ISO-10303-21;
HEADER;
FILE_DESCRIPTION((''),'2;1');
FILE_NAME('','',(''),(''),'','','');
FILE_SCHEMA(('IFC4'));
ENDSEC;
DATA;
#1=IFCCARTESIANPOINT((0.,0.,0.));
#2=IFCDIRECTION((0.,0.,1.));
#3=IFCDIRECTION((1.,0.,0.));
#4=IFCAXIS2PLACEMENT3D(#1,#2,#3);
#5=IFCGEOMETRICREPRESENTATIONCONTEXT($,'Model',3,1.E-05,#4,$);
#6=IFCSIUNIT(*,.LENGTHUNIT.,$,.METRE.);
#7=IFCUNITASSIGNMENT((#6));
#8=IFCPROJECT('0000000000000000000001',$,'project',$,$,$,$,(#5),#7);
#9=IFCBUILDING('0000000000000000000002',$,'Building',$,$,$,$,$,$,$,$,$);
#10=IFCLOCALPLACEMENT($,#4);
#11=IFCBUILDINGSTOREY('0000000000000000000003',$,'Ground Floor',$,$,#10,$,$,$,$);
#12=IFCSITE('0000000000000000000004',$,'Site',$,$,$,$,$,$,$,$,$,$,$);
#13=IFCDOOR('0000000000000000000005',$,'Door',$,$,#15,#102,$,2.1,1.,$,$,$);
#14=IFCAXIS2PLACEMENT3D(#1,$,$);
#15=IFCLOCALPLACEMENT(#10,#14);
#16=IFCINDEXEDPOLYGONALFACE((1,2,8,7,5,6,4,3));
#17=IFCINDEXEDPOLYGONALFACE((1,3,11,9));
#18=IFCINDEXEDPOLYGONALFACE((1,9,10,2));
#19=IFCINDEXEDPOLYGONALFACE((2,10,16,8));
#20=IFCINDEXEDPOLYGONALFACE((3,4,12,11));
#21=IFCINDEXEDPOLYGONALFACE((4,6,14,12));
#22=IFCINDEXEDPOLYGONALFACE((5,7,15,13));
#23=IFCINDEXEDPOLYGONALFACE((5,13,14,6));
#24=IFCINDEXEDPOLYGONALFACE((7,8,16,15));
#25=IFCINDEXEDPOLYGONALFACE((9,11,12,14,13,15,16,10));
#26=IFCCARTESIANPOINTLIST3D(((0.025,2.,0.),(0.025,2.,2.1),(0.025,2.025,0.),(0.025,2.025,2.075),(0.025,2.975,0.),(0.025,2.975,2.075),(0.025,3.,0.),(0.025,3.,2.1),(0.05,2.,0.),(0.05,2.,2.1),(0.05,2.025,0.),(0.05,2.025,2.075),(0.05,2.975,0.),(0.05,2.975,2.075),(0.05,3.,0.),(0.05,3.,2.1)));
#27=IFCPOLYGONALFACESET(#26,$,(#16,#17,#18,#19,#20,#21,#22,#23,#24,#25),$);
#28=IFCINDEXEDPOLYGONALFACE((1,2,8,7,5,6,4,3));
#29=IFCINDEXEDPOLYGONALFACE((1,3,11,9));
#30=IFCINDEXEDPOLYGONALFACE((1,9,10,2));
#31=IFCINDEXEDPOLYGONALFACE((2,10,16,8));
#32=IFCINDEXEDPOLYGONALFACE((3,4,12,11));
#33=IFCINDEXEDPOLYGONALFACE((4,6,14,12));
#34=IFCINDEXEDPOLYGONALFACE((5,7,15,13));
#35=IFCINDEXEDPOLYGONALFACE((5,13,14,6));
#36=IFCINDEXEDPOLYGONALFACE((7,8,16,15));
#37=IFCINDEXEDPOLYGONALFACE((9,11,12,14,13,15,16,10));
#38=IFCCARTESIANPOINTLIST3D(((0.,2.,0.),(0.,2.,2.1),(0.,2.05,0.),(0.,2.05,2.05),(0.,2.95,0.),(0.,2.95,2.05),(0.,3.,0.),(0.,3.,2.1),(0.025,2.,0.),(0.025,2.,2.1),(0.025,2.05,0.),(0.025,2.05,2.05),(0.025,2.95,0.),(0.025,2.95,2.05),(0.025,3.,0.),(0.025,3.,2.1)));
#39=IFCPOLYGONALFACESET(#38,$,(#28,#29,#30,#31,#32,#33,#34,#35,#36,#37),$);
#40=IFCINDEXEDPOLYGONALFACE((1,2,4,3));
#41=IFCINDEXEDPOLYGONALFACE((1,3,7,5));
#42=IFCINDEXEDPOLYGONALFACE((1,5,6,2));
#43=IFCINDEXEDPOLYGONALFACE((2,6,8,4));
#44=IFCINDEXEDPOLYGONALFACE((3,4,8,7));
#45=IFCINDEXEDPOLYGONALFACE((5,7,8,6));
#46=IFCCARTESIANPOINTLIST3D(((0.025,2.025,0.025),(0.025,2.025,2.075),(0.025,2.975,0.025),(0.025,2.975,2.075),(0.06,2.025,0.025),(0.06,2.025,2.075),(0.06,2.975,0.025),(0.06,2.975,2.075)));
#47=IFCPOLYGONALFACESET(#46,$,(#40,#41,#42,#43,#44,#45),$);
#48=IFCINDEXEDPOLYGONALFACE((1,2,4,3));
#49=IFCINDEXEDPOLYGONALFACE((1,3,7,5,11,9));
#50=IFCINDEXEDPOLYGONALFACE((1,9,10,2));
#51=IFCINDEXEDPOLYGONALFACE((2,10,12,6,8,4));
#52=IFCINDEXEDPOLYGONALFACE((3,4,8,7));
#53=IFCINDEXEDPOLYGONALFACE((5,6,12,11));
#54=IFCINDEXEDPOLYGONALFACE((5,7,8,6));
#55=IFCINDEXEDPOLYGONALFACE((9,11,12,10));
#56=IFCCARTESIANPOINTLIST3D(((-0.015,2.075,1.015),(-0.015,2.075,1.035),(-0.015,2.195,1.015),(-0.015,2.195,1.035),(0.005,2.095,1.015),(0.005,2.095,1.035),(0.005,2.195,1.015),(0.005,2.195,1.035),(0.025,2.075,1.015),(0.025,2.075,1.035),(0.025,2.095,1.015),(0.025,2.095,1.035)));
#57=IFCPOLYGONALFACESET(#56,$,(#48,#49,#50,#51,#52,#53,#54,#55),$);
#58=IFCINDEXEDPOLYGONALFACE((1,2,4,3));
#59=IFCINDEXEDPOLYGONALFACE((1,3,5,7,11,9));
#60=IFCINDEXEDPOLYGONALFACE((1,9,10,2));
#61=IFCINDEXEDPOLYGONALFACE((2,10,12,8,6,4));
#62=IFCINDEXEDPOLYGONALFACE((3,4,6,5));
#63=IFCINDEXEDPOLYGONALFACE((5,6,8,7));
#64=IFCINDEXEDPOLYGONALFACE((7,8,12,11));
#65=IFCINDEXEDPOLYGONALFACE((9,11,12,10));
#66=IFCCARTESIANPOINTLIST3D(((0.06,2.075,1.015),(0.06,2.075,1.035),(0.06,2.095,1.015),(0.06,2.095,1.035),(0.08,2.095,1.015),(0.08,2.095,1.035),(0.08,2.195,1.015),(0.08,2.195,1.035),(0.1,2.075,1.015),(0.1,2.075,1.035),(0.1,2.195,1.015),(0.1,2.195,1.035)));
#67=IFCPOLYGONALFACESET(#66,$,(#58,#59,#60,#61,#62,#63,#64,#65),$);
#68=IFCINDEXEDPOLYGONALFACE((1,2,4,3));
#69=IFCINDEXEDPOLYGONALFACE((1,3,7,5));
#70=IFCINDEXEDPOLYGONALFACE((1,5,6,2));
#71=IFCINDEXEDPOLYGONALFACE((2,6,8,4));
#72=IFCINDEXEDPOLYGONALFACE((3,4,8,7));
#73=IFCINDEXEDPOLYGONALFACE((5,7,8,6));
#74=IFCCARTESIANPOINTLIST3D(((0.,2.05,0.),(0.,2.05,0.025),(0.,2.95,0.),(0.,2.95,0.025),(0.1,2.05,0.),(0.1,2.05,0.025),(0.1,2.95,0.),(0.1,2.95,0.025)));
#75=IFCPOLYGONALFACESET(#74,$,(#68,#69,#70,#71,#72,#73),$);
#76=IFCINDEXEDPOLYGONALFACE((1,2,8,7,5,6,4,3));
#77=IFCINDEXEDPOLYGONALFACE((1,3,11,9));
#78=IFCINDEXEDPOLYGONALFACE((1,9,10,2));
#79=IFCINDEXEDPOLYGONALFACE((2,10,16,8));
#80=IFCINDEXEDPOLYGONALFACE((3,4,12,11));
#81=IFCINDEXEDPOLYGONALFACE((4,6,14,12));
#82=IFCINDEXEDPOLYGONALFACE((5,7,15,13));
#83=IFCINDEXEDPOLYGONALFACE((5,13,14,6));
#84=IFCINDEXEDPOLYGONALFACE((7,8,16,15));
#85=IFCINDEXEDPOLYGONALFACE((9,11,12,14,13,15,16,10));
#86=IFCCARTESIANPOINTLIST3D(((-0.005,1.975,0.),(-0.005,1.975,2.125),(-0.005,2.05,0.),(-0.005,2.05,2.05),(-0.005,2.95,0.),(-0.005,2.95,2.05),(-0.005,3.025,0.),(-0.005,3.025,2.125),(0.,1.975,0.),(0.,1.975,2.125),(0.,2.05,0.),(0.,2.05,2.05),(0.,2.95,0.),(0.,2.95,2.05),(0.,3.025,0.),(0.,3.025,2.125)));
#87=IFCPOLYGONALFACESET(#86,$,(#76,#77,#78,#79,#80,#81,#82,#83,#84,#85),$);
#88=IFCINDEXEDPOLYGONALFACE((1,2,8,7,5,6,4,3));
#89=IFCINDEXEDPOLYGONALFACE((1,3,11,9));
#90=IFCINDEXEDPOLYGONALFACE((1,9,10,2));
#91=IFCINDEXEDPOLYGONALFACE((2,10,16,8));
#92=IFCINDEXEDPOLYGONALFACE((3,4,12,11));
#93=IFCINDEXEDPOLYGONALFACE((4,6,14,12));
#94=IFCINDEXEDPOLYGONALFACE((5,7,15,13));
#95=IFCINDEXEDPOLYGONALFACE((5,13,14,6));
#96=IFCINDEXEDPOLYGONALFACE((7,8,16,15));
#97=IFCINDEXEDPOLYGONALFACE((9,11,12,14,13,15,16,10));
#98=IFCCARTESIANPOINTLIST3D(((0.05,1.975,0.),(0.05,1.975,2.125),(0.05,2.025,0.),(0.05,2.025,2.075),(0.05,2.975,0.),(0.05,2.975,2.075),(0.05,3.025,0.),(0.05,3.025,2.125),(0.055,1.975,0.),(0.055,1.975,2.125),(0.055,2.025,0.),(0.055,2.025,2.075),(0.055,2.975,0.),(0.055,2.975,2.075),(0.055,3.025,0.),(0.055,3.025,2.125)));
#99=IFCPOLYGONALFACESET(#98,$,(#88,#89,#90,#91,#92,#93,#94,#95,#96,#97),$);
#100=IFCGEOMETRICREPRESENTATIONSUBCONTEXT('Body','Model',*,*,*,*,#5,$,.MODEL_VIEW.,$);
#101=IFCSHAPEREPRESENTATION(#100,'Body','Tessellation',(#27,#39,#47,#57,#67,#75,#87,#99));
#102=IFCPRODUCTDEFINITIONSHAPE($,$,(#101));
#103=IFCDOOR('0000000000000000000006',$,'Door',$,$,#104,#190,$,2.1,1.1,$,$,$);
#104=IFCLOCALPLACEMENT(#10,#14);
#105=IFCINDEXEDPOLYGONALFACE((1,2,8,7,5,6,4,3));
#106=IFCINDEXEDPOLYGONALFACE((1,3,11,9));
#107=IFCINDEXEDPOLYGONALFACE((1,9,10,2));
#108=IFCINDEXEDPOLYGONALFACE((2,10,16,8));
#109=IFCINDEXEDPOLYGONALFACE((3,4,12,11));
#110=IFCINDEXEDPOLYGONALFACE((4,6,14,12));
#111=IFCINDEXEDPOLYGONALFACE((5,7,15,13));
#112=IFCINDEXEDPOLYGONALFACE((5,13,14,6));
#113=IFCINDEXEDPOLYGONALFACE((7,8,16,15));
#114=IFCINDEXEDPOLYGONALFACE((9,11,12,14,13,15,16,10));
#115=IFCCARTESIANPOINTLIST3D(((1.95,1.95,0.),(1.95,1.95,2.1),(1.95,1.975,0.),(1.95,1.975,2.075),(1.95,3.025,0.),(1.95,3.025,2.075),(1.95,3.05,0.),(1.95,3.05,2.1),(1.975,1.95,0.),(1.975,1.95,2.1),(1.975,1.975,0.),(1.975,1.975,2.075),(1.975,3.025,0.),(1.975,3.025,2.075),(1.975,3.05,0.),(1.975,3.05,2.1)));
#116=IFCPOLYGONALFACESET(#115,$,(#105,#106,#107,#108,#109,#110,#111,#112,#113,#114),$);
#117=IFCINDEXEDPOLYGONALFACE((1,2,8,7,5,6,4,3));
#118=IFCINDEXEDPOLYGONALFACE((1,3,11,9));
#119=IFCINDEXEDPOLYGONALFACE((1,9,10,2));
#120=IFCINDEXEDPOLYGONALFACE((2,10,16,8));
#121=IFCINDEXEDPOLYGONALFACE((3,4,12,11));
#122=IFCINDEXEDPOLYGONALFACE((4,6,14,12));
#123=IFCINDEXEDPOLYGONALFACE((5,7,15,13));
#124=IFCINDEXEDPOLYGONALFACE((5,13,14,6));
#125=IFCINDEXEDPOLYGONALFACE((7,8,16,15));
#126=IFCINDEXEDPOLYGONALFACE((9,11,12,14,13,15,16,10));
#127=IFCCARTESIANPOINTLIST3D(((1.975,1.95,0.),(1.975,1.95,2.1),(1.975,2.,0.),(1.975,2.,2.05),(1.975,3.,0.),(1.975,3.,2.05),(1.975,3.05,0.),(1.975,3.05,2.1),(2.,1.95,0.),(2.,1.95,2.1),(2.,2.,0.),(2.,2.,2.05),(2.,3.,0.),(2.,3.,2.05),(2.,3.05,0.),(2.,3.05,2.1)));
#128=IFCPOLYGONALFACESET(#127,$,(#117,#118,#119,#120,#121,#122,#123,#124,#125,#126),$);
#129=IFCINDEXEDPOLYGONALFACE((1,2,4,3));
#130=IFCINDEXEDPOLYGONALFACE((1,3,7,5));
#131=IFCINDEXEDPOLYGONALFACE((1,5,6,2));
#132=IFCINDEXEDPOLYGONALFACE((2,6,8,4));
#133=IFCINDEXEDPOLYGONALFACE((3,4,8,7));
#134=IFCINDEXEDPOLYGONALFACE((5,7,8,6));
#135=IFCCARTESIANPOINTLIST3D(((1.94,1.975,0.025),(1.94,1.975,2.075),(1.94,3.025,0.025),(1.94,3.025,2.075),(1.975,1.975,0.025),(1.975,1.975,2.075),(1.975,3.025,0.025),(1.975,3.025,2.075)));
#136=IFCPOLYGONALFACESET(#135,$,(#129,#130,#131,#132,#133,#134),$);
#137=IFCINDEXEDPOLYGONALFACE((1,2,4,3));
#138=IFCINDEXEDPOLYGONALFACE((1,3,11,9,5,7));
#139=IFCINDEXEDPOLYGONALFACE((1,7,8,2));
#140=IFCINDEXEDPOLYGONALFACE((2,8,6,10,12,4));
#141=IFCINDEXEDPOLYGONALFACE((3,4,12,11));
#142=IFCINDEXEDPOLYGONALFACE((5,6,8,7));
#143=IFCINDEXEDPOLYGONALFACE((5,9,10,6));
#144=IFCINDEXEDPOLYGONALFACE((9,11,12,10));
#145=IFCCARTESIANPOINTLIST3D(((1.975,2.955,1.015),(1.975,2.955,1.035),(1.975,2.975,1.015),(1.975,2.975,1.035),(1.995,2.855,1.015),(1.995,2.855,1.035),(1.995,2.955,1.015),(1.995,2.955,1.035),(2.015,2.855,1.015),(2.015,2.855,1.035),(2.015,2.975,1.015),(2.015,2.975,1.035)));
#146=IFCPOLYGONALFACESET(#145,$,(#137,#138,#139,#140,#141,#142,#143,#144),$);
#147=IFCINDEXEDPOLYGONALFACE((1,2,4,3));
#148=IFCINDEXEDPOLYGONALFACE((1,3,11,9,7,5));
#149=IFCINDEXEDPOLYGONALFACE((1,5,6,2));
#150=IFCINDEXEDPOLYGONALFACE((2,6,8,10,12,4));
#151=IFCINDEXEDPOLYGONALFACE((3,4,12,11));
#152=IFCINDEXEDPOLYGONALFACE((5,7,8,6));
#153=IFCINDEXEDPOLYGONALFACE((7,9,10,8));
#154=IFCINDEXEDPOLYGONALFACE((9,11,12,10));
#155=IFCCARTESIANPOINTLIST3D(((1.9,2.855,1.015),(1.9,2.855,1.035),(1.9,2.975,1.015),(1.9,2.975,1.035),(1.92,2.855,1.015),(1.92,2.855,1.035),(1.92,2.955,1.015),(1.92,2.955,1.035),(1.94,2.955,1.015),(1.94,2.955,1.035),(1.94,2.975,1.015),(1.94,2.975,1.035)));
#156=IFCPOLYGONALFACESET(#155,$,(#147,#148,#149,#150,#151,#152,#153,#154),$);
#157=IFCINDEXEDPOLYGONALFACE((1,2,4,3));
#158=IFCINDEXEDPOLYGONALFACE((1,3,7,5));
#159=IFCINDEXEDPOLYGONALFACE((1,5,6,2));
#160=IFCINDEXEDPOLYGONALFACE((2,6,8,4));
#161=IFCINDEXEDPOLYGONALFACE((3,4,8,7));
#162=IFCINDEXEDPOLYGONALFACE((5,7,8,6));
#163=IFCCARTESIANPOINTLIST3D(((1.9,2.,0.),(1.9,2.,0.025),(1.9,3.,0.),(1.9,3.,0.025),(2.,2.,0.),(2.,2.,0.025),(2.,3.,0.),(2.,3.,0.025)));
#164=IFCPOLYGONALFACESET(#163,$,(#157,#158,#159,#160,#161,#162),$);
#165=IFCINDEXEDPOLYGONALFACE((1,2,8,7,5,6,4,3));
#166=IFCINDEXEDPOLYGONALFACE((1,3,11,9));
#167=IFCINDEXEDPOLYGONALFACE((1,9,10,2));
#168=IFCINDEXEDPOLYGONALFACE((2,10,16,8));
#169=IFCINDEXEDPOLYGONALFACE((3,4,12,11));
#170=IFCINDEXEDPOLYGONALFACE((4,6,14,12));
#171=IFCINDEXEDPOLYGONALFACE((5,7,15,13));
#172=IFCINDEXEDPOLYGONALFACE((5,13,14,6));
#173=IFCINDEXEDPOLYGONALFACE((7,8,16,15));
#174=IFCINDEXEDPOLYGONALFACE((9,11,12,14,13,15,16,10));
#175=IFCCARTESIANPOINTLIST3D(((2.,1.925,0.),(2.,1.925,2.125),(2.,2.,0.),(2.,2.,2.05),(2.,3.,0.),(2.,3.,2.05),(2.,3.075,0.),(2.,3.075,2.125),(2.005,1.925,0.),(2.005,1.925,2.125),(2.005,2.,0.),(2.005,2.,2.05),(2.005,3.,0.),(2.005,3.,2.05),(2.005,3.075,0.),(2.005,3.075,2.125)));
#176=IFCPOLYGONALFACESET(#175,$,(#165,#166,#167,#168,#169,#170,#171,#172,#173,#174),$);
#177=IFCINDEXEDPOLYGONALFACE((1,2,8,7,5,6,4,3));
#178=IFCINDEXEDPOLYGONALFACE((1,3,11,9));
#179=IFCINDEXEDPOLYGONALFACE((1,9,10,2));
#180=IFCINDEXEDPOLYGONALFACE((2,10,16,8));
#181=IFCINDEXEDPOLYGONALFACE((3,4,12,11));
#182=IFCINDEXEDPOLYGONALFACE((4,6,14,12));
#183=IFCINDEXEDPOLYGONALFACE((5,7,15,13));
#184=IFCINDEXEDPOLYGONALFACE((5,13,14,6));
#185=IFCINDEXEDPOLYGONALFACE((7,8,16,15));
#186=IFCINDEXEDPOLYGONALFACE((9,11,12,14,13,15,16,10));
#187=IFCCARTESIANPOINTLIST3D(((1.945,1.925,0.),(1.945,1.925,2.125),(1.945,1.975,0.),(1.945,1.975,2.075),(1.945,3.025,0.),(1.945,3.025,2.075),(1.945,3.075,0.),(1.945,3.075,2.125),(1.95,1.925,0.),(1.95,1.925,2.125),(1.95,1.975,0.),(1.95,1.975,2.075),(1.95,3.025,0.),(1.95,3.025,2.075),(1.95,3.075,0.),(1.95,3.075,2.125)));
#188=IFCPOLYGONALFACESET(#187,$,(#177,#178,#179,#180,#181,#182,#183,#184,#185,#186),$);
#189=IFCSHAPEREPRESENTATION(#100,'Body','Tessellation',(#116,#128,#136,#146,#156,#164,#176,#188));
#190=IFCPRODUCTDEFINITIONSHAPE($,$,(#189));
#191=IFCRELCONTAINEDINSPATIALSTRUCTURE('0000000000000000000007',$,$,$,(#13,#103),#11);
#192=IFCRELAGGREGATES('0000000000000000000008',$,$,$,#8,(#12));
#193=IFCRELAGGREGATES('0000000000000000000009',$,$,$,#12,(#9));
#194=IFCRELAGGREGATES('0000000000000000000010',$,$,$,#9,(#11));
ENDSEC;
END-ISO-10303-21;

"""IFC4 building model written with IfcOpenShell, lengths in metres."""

from ifc_helpers import new_model, si_unit, frame, origin_with_axes, place, context, subcontext, project, spatial, line, indexed_curve, outline, extrude, element, save


model = new_model("IFC4")

# Units and contexts
model_context = context("Model", 3, precision=1e-05, world=origin_with_axes())
body_context = subcontext(model_context, "Body", "Model", "MODEL_VIEW")
ifc_project = project(units=[si_unit("LENGTHUNIT", "METRE")], contexts=[model_context])

# Site, building, storey
site = spatial("IfcSite", under=ifc_project, Name="Site")
building = spatial("IfcBuilding", under=site, Name="Building")
storey_placement = place(None, origin_with_axes())
storey = spatial("IfcBuildingStorey", under=building, at=storey_placement, Name="Ground Floor")

# Doors
door_1_placement = place(storey_placement, frame((0.0, 3.0, 0.0), z_axis=(0.0, 0.0, 1.0), x_axis=(0.0, -1.0, 0.0)))
element("IfcDoor", 1, at=door_1_placement, inside=storey, Name="Door", OverallHeight=2.1, OverallWidth=1.0, context=body_context, shape_type="SweptSolid", body=[
    extrude(outline(indexed_curve([(0.0, 0.0), (0.0, 2.1), (1.0, 2.1), (1.0, 0.0), (0.975, 0.0), (0.975, 2.075), (0.025, 2.075), (0.025, 0.0)], segments=[line(1, 2, 3, 4, 5, 6, 7, 8, 1)])), frame((0.0, 0.025, 0.0), z_axis=(0.0, -1.0, 0.0), x_axis=(1.0, 0.0, 0.0)), (0.0, 0.0, -1.0), 0.025),
    extrude(outline(indexed_curve([(0.0, 0.0), (0.0, 2.1), (1.0, 2.1), (1.0, 0.0), (0.95, 0.0), (0.95, 2.05), (0.05, 2.05), (0.05, 0.0)], segments=[line(1, 2, 3, 4, 5, 6, 7, 8, 1)])), frame((0.0, 0.0, 0.0), z_axis=(0.0, -1.0, 0.0), x_axis=(1.0, 0.0, 0.0)), (0.0, 0.0, -1.0), 0.025),
    extrude(outline(indexed_curve([(0.0, 0.0), (0.95, 0.0), (0.95, 0.035), (0.0, 0.035)], segments=[line(1, 2, 3, 4, 1)])), frame((0.025, 0.025, 0.025), z_axis=(0.0, 0.0, 1.0), x_axis=(1.0, 0.0, 0.0)), (0.0, 0.0, 1.0), 2.05),
    extrude(outline(indexed_curve([(0.0, 0.0), (0.0, -0.04), (-0.12, -0.04), (-0.12, -0.02), (-0.02, -0.02), (-0.02, 0.0)], segments=[line(1, 2, 3, 4, 5, 6, 1)])), frame((0.925, 0.025, 1.015), z_axis=(0.0, 0.0, 1.0), x_axis=(1.0, 0.0, 0.0)), (0.0, 0.0, 1.0), 0.02),
    extrude(outline(indexed_curve([(0.0, 0.0), (0.0, 0.04), (-0.12, 0.04), (-0.12, 0.02), (-0.02, 0.02), (-0.02, 0.0)], segments=[line(1, 2, 3, 4, 5, 6, 1)])), frame((0.925, 0.06, 1.015), z_axis=(0.0, 0.0, 1.0), x_axis=(1.0, 0.0, 0.0)), (0.0, 0.0, 1.0), 0.02),
    extrude(outline(indexed_curve([(0.0, 0.0), (0.9, 0.0), (0.9, 0.1), (0.0, 0.1)], segments=[line(1, 2, 3, 4, 1)])), frame((0.05, 0.0, 0.0), z_axis=(0.0, 0.0, 1.0), x_axis=(1.0, 0.0, 0.0)), (0.0, 0.0, 1.0), 0.025),
    extrude(outline(indexed_curve([(0.0, 0.0), (0.0, 2.125), (1.05, 2.125), (1.05, 0.0), (0.975, 0.0), (0.975, 2.05), (0.075, 2.05), (0.075, 0.0)], segments=[line(1, 2, 3, 4, 5, 6, 7, 8, 1)])), frame((-0.025, -0.005, 0.0), z_axis=(0.0, -1.0, 0.0), x_axis=(1.0, 0.0, 0.0)), (0.0, 0.0, -1.0), 0.005),
    extrude(outline(indexed_curve([(0.0, 0.0), (0.0, 2.125), (1.05, 2.125), (1.05, 0.0), (1.0, 0.0), (1.0, 2.075), (0.05, 2.075), (0.05, 0.0)], segments=[line(1, 2, 3, 4, 5, 6, 7, 8, 1)])), frame((-0.025, 0.05, 0.0), z_axis=(0.0, -1.0, 0.0), x_axis=(1.0, 0.0, 0.0)), (0.0, 0.0, -1.0), 0.005),
])
door_2_placement = place(storey_placement, frame((2.0, 1.95, 0.0), z_axis=(0.0, 0.0, 1.0), x_axis=(0.0, 1.0, 0.0)))
element("IfcDoor", 2, at=door_2_placement, inside=storey, Name="Door", OverallHeight=2.1, OverallWidth=1.1, context=body_context, shape_type="SweptSolid", body=[
    extrude(outline(indexed_curve([(0.0, 0.0), (0.0, 2.1), (1.1, 2.1), (1.1, 0.0), (1.075, 0.0), (1.075, 2.075), (0.025, 2.075), (0.025, 0.0)], segments=[line(1, 2, 3, 4, 5, 6, 7, 8, 1)])), frame((0.0, 0.025, 0.0), z_axis=(0.0, -1.0, 0.0), x_axis=(1.0, 0.0, 0.0)), (0.0, 0.0, -1.0), 0.025),
    extrude(outline(indexed_curve([(0.0, 0.0), (0.0, 2.1), (1.1, 2.1), (1.1, 0.0), (1.05, 0.0), (1.05, 2.05), (0.05, 2.05), (0.05, 0.0)], segments=[line(1, 2, 3, 4, 5, 6, 7, 8, 1)])), frame((0.0, 0.0, 0.0), z_axis=(0.0, -1.0, 0.0), x_axis=(1.0, 0.0, 0.0)), (0.0, 0.0, -1.0), 0.025),
    extrude(outline(indexed_curve([(0.0, 0.0), (1.05, 0.0), (1.05, 0.035), (0.0, 0.035)], segments=[line(1, 2, 3, 4, 1)])), frame((0.025, 0.025, 0.025), z_axis=(0.0, 0.0, 1.0), x_axis=(1.0, 0.0, 0.0)), (0.0, 0.0, 1.0), 2.05),
    extrude(outline(indexed_curve([(0.0, 0.0), (0.0, -0.04), (-0.12, -0.04), (-0.12, -0.02), (-0.02, -0.02), (-0.02, 0.0)], segments=[line(1, 2, 3, 4, 5, 6, 1)])), frame((1.025, 0.025, 1.015), z_axis=(0.0, 0.0, 1.0), x_axis=(1.0, 0.0, 0.0)), (0.0, 0.0, 1.0), 0.02),
    extrude(outline(indexed_curve([(0.0, 0.0), (0.0, 0.04), (-0.12, 0.04), (-0.12, 0.02), (-0.02, 0.02), (-0.02, 0.0)], segments=[line(1, 2, 3, 4, 5, 6, 1)])), frame((1.025, 0.06, 1.015), z_axis=(0.0, 0.0, 1.0), x_axis=(1.0, 0.0, 0.0)), (0.0, 0.0, 1.0), 0.02),
    extrude(outline(indexed_curve([(0.0, 0.0), (1.0, 0.0), (1.0, 0.1), (0.0, 0.1)], segments=[line(1, 2, 3, 4, 1)])), frame((0.05, 0.0, 0.0), z_axis=(0.0, 0.0, 1.0), x_axis=(1.0, 0.0, 0.0)), (0.0, 0.0, 1.0), 0.025),
    extrude(outline(indexed_curve([(0.0, 0.0), (0.0, 2.125), (1.15, 2.125), (1.15, 0.0), (1.075, 0.0), (1.075, 2.05), (0.075, 2.05), (0.075, 0.0)], segments=[line(1, 2, 3, 4, 5, 6, 7, 8, 1)])), frame((-0.025, -0.005, 0.0), z_axis=(0.0, -1.0, 0.0), x_axis=(1.0, 0.0, 0.0)), (0.0, 0.0, -1.0), 0.005),
    extrude(outline(indexed_curve([(0.0, 0.0), (0.0, 2.125), (1.15, 2.125), (1.15, 0.0), (1.1, 0.0), (1.1, 2.075), (0.05, 2.075), (0.05, 0.0)], segments=[line(1, 2, 3, 4, 5, 6, 7, 8, 1)])), frame((-0.025, 0.05, 0.0), z_axis=(0.0, -1.0, 0.0), x_axis=(1.0, 0.0, 0.0)), (0.0, 0.0, -1.0), 0.005),
])

save(model, "model.ifc")
